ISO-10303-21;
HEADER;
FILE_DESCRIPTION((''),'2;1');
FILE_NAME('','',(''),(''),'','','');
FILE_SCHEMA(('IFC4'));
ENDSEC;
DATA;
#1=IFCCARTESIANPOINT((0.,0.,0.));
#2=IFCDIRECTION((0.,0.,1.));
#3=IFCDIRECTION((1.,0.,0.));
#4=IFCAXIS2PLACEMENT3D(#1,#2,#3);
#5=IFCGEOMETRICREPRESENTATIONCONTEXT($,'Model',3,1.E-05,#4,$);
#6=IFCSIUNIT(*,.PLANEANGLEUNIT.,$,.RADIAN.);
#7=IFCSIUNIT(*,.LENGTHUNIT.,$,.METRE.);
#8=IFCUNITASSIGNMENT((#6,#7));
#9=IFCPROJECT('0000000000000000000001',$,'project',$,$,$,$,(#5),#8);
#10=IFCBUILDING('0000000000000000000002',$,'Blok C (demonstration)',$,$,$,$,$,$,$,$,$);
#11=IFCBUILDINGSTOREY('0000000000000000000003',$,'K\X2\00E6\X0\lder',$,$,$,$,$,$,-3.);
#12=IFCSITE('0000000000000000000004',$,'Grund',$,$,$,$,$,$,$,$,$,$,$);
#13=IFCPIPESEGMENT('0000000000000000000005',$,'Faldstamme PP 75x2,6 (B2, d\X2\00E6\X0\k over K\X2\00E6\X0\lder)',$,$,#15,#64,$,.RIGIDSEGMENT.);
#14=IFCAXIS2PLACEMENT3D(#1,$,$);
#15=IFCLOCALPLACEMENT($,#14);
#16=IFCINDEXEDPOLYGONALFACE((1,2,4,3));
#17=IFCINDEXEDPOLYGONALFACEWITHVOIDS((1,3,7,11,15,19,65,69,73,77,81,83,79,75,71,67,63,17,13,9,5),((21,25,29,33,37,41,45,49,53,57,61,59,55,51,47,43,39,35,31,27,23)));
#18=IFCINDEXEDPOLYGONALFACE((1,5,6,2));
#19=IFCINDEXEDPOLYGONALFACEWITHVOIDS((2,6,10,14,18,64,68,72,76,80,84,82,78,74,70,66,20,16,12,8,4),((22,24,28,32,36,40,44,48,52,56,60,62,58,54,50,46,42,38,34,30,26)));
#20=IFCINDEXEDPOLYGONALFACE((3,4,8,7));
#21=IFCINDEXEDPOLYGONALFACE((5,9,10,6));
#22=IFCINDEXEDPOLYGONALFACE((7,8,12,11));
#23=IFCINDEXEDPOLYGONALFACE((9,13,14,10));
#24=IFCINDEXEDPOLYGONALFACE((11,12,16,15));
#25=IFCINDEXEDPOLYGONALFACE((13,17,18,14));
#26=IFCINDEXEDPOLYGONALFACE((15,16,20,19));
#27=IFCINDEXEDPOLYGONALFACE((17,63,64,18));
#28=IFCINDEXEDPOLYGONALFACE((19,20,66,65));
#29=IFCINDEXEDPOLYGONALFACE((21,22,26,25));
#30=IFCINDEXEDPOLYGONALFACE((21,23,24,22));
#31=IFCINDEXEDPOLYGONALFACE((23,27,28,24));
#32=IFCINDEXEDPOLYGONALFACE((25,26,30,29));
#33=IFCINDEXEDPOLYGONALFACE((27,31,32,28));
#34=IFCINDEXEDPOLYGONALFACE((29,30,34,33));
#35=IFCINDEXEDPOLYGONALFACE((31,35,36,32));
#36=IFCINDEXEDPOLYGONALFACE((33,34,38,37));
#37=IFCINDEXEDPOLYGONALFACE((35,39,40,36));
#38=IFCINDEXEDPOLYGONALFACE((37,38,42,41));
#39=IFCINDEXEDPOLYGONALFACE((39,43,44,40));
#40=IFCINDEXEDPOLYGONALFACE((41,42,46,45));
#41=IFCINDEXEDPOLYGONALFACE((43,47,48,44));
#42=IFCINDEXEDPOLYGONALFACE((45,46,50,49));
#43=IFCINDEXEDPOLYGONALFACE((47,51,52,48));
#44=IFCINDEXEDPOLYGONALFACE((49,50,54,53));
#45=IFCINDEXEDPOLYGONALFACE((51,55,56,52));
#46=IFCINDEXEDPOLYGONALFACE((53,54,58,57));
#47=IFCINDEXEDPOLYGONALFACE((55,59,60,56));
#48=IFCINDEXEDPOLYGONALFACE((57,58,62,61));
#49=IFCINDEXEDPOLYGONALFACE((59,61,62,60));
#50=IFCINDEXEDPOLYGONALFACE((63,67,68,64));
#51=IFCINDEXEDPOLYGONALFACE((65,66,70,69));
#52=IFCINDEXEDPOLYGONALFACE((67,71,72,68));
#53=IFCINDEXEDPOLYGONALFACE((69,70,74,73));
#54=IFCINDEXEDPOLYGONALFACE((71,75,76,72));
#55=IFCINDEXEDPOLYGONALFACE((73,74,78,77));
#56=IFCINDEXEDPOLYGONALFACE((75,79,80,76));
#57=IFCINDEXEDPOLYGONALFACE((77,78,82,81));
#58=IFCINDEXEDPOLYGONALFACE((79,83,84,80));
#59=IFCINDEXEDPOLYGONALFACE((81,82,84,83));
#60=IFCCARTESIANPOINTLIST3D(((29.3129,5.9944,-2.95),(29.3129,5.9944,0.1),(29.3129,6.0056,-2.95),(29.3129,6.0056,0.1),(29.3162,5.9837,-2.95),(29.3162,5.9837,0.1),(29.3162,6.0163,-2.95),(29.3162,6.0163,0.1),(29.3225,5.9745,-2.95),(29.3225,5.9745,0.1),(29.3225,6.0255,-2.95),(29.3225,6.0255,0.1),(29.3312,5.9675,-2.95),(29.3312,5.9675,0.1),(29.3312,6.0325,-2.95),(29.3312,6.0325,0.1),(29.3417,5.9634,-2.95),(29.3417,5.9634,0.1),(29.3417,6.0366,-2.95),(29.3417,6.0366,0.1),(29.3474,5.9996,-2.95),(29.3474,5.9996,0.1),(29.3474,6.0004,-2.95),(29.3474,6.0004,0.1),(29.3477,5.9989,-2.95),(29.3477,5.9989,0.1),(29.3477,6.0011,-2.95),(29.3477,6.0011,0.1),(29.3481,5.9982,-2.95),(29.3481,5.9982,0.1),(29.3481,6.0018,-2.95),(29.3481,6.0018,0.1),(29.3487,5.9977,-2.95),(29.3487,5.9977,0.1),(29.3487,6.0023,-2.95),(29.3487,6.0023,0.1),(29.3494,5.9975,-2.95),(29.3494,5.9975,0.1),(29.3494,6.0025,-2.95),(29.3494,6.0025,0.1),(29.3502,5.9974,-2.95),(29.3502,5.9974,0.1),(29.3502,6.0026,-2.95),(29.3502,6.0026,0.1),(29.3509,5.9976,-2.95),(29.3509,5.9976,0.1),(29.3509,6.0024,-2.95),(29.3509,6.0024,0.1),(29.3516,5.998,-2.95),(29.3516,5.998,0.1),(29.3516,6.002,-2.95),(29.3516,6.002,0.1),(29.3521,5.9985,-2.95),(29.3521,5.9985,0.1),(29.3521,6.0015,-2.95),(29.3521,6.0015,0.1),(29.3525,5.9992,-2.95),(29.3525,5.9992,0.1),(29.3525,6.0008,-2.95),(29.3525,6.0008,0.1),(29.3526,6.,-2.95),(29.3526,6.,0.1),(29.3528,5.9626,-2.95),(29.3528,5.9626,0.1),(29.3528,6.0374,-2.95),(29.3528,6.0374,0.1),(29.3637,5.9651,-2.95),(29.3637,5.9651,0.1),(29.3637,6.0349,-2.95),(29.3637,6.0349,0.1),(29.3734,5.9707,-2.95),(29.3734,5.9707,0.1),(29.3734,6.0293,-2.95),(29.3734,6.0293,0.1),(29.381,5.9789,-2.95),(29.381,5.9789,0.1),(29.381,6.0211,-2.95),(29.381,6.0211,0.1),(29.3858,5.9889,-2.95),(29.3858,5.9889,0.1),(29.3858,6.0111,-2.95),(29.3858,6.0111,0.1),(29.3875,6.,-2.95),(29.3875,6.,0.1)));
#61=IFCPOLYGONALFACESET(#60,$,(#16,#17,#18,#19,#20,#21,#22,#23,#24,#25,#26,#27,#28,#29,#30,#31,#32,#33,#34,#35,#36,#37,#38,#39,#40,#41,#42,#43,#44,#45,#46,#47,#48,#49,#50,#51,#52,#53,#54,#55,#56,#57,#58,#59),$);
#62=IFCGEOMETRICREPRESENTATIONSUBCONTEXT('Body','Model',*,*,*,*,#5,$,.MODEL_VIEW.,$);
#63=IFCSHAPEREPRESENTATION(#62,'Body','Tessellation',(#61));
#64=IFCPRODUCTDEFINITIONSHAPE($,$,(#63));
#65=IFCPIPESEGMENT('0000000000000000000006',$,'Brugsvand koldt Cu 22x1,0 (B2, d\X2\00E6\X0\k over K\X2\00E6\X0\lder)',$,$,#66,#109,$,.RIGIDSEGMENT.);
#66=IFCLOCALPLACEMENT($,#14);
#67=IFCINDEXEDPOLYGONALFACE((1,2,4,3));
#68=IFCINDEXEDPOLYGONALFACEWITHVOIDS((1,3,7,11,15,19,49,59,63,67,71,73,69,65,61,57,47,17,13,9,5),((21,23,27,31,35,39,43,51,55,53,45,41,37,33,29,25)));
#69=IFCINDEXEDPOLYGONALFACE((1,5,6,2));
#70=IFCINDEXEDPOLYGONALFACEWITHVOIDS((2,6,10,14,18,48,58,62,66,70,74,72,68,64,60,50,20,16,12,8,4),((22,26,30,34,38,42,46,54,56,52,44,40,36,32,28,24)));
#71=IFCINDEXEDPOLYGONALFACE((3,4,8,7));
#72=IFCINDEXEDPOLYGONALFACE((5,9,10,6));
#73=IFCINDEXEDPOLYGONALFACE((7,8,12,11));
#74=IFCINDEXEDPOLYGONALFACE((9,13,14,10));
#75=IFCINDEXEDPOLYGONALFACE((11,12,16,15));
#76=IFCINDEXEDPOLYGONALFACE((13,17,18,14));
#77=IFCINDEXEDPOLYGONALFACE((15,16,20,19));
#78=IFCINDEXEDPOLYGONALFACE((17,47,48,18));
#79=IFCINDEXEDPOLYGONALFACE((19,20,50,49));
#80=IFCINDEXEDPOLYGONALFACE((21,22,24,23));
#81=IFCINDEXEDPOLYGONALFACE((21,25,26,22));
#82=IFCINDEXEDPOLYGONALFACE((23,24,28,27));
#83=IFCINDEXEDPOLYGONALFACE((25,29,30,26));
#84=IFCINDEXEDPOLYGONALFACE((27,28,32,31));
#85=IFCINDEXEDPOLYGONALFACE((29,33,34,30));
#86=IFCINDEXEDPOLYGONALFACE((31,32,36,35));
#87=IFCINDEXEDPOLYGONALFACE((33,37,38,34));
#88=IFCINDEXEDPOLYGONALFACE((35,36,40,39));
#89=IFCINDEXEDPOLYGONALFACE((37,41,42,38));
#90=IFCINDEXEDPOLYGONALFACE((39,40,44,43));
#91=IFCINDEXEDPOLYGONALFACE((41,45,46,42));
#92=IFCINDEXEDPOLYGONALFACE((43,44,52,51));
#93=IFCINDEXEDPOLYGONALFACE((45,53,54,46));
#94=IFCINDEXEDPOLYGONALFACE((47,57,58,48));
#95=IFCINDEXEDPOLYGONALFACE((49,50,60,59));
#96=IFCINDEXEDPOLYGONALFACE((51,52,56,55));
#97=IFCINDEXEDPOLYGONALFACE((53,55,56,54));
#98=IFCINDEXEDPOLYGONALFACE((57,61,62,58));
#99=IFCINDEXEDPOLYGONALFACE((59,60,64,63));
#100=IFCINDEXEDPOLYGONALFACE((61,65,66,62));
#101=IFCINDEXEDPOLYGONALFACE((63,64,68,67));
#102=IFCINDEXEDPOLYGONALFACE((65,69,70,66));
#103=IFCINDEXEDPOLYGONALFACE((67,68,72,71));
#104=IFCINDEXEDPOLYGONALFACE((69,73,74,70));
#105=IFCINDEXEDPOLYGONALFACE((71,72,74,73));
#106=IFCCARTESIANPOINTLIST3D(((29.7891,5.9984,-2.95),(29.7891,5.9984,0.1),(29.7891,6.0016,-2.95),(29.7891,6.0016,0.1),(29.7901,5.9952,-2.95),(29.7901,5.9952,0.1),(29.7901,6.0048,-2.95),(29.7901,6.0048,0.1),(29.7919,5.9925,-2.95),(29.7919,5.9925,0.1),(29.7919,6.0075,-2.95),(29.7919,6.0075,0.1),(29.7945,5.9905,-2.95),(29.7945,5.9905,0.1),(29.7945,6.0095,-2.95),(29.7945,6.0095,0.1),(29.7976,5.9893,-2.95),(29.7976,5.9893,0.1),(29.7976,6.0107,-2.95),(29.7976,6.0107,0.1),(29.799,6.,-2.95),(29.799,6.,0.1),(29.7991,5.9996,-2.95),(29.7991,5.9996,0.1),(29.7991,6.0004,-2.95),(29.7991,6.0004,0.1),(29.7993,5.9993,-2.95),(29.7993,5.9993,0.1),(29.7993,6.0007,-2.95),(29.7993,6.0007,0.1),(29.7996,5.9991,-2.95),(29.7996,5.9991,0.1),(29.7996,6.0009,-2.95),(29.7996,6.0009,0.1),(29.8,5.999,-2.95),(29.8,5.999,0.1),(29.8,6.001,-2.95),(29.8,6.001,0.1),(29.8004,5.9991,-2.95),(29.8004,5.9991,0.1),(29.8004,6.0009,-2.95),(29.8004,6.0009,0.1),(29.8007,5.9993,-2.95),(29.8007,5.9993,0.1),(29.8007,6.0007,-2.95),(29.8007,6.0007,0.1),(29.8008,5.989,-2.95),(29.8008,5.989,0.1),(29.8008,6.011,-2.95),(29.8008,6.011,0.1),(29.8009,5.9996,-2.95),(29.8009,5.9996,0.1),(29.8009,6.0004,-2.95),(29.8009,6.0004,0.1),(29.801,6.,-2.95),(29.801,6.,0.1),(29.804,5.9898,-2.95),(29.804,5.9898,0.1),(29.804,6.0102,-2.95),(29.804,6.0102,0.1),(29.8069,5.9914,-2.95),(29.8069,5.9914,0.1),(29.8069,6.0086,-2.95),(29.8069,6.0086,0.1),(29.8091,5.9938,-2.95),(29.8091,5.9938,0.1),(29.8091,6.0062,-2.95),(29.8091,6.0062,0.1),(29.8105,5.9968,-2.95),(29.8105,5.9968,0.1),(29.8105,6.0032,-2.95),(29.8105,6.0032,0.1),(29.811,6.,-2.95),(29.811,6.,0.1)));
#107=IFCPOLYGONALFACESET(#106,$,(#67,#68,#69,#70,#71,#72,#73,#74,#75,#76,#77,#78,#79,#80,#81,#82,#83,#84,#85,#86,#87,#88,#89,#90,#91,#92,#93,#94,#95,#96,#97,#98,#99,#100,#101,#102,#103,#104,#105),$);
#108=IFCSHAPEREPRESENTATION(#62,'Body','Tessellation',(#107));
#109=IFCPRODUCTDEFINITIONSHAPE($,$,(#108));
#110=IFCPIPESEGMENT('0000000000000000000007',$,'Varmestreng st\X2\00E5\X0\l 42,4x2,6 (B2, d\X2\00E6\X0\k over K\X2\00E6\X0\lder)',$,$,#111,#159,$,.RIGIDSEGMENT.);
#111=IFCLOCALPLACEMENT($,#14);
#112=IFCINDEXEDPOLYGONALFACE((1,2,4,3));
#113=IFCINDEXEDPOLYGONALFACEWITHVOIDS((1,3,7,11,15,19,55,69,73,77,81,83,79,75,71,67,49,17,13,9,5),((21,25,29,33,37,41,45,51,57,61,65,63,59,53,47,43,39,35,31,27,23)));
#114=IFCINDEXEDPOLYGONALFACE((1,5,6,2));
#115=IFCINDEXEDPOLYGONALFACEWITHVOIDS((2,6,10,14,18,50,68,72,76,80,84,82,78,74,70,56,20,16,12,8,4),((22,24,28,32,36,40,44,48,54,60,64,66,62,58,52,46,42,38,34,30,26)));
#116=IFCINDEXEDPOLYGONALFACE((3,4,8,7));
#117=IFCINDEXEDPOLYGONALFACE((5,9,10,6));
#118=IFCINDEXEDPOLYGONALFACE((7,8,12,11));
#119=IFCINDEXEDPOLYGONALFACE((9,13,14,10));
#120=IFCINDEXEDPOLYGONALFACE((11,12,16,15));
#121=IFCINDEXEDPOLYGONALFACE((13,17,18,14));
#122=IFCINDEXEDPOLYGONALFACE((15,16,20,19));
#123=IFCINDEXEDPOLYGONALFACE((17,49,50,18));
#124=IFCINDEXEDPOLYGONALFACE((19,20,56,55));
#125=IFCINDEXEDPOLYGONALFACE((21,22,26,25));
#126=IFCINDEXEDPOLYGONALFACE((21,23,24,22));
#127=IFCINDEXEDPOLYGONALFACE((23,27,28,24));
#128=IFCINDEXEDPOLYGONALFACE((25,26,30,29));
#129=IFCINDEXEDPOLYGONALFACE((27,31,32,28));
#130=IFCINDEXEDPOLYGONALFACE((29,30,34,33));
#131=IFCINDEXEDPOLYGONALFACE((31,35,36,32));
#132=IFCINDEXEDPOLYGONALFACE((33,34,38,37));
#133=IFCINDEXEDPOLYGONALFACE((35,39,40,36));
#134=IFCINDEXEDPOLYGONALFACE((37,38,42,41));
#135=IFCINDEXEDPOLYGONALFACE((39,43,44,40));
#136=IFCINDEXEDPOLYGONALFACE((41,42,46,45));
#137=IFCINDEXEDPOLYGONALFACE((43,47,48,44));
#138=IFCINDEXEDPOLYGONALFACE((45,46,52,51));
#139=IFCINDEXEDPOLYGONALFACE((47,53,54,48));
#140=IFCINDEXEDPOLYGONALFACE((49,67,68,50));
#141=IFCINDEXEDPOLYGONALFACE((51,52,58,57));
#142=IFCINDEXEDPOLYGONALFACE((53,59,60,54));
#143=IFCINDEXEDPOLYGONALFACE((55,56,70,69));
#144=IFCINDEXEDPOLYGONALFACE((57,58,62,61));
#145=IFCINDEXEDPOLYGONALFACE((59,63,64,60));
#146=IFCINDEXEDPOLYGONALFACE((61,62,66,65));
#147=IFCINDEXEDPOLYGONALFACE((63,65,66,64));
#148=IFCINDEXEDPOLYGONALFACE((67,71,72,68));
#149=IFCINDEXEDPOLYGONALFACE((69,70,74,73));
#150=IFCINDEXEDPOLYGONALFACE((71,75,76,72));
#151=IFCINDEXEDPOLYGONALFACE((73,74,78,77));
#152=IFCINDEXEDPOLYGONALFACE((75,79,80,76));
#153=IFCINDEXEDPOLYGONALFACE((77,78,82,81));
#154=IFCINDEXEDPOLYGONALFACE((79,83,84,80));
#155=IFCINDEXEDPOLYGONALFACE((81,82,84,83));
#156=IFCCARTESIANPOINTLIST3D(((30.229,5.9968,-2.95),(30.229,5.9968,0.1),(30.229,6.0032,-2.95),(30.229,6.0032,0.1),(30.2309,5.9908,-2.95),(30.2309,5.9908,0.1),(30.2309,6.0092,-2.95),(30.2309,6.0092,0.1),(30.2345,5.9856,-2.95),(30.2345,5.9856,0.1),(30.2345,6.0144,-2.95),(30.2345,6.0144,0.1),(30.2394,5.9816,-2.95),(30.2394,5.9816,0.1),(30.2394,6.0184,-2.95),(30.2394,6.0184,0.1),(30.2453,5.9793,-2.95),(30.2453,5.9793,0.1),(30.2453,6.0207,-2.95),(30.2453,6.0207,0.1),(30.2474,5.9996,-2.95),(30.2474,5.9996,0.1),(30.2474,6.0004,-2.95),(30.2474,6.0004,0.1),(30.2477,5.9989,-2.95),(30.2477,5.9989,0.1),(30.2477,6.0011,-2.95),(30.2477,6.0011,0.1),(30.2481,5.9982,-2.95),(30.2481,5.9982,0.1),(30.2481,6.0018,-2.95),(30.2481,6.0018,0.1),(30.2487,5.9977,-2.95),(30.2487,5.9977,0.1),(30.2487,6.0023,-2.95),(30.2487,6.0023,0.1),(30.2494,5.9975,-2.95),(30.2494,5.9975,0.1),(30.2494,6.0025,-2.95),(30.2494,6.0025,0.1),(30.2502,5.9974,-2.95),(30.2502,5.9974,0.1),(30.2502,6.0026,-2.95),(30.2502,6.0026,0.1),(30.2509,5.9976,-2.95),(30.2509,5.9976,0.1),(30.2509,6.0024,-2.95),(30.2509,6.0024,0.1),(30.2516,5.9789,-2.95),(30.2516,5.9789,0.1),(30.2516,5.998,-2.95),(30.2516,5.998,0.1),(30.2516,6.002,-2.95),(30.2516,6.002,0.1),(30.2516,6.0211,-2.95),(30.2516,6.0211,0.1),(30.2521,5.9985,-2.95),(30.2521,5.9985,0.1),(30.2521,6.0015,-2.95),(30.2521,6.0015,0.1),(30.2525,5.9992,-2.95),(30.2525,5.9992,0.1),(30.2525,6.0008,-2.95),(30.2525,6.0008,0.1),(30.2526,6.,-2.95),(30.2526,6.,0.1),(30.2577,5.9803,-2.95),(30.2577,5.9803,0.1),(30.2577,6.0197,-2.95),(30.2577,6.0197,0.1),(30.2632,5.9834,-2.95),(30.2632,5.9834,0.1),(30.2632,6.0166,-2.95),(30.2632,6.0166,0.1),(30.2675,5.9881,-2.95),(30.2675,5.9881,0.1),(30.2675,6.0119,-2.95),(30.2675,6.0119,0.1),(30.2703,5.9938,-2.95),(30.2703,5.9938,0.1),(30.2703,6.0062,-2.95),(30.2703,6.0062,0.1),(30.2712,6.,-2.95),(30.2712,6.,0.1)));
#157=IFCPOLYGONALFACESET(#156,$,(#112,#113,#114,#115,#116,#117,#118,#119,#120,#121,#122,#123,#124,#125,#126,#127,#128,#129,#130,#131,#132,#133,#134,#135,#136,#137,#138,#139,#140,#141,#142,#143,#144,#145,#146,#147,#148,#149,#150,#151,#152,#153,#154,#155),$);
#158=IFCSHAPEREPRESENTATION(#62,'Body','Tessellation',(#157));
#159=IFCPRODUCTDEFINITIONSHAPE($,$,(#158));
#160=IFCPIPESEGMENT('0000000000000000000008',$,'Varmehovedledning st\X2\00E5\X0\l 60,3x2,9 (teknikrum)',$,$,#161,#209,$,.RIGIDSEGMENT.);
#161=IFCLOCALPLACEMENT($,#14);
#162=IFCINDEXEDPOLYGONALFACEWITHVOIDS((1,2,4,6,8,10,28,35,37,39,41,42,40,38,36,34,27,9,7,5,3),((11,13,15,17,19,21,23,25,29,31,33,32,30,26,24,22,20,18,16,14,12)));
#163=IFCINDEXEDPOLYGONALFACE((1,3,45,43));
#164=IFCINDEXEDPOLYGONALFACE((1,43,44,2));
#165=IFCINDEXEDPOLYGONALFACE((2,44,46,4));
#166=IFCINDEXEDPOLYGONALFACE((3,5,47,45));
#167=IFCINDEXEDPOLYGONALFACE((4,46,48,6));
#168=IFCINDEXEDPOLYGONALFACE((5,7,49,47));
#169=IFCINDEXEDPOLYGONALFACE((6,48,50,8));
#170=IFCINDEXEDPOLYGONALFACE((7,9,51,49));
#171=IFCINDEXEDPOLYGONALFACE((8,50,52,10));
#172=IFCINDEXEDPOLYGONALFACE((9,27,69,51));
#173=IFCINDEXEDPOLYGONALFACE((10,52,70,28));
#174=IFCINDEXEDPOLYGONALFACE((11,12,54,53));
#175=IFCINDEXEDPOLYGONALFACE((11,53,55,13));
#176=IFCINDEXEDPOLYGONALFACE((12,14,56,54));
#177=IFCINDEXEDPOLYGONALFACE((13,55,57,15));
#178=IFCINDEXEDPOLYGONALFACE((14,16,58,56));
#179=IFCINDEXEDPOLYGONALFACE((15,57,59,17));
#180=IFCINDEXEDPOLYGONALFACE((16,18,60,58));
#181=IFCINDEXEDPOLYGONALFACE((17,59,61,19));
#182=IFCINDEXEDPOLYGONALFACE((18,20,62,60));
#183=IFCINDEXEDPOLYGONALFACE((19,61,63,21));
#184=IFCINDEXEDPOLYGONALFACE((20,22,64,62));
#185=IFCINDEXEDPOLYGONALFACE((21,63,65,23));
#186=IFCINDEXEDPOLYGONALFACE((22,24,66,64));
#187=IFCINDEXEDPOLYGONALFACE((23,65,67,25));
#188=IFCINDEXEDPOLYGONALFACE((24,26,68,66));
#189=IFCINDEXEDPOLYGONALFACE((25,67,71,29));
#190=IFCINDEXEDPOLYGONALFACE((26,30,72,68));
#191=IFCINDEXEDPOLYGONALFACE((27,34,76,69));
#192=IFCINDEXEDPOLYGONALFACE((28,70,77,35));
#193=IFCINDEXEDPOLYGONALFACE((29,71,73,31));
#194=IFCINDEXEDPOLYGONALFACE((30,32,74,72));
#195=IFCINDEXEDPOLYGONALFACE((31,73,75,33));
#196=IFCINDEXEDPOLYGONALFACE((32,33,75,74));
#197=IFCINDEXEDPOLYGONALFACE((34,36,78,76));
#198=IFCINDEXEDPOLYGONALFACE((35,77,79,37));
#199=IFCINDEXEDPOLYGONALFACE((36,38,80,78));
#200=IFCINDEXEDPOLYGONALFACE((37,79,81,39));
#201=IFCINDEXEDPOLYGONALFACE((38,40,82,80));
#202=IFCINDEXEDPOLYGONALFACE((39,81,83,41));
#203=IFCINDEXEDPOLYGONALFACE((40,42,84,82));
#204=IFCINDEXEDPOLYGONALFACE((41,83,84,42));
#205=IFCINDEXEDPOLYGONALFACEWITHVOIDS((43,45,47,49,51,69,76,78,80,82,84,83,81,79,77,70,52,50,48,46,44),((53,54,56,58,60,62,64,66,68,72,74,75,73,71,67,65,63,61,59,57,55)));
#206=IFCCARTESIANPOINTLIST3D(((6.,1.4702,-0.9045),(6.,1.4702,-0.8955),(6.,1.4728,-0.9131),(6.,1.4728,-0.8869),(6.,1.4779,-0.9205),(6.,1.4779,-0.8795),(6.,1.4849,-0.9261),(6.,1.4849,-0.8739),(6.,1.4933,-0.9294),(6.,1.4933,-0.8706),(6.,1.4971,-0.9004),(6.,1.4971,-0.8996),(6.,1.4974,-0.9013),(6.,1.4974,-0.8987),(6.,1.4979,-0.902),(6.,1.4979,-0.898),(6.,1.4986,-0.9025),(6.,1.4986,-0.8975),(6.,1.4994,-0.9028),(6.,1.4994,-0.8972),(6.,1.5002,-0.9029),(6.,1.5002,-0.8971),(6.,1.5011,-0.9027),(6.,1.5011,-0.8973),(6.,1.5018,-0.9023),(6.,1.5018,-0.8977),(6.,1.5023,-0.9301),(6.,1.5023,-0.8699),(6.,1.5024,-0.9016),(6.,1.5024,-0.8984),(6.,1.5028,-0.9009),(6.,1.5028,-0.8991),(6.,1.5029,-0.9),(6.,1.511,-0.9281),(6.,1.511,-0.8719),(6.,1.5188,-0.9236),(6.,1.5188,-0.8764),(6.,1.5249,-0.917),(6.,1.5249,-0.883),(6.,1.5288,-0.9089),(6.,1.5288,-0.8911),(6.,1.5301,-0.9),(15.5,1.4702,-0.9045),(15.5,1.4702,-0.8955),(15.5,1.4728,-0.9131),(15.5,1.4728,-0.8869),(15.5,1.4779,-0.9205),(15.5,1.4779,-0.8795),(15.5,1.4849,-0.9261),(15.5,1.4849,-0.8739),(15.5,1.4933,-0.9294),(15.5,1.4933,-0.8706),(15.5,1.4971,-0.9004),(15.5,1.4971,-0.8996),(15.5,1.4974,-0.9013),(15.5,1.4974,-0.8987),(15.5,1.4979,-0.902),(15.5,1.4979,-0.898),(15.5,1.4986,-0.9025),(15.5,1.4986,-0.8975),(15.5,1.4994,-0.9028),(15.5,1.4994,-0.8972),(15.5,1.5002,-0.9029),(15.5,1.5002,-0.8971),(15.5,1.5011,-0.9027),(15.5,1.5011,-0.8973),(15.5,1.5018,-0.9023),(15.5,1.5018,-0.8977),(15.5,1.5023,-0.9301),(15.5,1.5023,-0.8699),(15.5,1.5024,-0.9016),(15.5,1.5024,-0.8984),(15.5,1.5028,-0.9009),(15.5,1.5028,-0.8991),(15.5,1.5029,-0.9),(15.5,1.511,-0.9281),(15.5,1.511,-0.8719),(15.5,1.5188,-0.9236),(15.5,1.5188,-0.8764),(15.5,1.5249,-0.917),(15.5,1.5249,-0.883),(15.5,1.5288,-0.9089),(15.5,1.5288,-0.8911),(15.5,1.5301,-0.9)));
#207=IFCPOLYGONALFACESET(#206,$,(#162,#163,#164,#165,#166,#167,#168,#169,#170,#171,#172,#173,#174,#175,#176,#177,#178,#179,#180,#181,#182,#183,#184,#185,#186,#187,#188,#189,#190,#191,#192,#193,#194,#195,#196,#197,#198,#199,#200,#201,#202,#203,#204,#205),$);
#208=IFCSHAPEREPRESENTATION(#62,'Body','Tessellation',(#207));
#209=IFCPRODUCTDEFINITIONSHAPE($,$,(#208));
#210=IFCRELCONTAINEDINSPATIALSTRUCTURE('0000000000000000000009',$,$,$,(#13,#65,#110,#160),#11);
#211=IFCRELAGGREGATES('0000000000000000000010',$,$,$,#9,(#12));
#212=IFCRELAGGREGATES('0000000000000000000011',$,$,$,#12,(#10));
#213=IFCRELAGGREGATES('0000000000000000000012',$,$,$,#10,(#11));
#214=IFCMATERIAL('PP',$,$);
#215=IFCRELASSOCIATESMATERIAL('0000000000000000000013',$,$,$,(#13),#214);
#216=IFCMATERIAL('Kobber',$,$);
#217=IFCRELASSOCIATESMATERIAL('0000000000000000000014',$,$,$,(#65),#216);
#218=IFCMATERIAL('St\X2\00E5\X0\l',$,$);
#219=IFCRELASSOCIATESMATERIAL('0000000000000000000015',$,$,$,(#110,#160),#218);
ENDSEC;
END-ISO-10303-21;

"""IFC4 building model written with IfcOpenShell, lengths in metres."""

from ifc_helpers import new_model, si_unit, frame, origin_with_axes, place, context, subcontext, project, spatial, hollow_circle, extrude, material, element, save


model = new_model("IFC4")

# Units and contexts
model_context = context("Model", 3, precision=1e-05, world=origin_with_axes())
body_context = subcontext(model_context, "Body", "Model", "MODEL_VIEW")
ifc_project = project(units=[si_unit("PLANEANGLEUNIT", "RADIAN"), si_unit("LENGTHUNIT", "METRE")], contexts=[model_context])

# Site, building, storey
site = spatial("IfcSite", under=ifc_project, Name="Grund")
building = spatial("IfcBuilding", under=site, Name="Blok C (demonstration)")
storey = spatial("IfcBuildingStorey", under=building, Name="Kælder", Elevation=-3.0)

# Pipe segments
ifc_material_1 = material(Name="Kobber")
ifc_material_2 = material(Name="PP")
pipe_segment_1_placement = place(None, origin_with_axes())
element("IfcPipeSegment", 1, at=pipe_segment_1_placement, inside=storey, material=ifc_material_2, Name="Faldstamme PP 75x2,6 (B2, dæk over Kælder)", PredefinedType="RIGIDSEGMENT", context=body_context, shape_type="SweptSolid", body=[
    extrude(hollow_circle(Radius=0.0375, WallThickness=0.0349), frame((29.35, 6.0, -2.95), z_axis=(0.0, 0.0, 1.0), x_axis=(1.0, 0.0, 0.0)), (0.0, 0.0, 1.0), 3.05),
])
pipe_segment_2_placement = place(None, origin_with_axes())
element("IfcPipeSegment", 2, at=pipe_segment_2_placement, inside=storey, material=ifc_material_1, Name="Brugsvand koldt Cu 22x1,0 (B2, dæk over Kælder)", PredefinedType="RIGIDSEGMENT", context=body_context, shape_type="SweptSolid", body=[
    extrude(hollow_circle(Radius=0.011, WallThickness=0.01), frame((29.8, 6.0, -2.95), z_axis=(0.0, 0.0, 1.0), x_axis=(1.0, 0.0, 0.0)), (0.0, 0.0, 1.0), 3.05),
])
ifc_material_3 = material(Name="Stål")
pipe_segment_3_placement = place(None, origin_with_axes())
element("IfcPipeSegment", 3, at=pipe_segment_3_placement, inside=storey, material=ifc_material_3, Name="Varmestreng stål 42,4x2,6 (B2, dæk over Kælder)", PredefinedType="RIGIDSEGMENT", context=body_context, shape_type="SweptSolid", body=[
    extrude(hollow_circle(Radius=0.0212, WallThickness=0.0186), frame((30.25, 6.0, -2.95), z_axis=(0.0, 0.0, 1.0), x_axis=(1.0, 0.0, 0.0)), (0.0, 0.0, 1.0), 3.05),
])
pipe_segment_4_placement = place(None, origin_with_axes())
element("IfcPipeSegment", 4, at=pipe_segment_4_placement, inside=storey, material=ifc_material_3, Name="Varmehovedledning stål 60,3x2,9 (teknikrum)", PredefinedType="RIGIDSEGMENT", context=body_context, shape_type="SweptSolid", body=[
    extrude(hollow_circle(Radius=0.0301, WallThickness=0.0272), frame((6.0, 1.5, -0.9), z_axis=(1.0, 0.0, 0.0), x_axis=(0.0, 1.0, 0.0)), (0.0, 0.0, 1.0), 9.5),
])

save(model, "model.ifc")
